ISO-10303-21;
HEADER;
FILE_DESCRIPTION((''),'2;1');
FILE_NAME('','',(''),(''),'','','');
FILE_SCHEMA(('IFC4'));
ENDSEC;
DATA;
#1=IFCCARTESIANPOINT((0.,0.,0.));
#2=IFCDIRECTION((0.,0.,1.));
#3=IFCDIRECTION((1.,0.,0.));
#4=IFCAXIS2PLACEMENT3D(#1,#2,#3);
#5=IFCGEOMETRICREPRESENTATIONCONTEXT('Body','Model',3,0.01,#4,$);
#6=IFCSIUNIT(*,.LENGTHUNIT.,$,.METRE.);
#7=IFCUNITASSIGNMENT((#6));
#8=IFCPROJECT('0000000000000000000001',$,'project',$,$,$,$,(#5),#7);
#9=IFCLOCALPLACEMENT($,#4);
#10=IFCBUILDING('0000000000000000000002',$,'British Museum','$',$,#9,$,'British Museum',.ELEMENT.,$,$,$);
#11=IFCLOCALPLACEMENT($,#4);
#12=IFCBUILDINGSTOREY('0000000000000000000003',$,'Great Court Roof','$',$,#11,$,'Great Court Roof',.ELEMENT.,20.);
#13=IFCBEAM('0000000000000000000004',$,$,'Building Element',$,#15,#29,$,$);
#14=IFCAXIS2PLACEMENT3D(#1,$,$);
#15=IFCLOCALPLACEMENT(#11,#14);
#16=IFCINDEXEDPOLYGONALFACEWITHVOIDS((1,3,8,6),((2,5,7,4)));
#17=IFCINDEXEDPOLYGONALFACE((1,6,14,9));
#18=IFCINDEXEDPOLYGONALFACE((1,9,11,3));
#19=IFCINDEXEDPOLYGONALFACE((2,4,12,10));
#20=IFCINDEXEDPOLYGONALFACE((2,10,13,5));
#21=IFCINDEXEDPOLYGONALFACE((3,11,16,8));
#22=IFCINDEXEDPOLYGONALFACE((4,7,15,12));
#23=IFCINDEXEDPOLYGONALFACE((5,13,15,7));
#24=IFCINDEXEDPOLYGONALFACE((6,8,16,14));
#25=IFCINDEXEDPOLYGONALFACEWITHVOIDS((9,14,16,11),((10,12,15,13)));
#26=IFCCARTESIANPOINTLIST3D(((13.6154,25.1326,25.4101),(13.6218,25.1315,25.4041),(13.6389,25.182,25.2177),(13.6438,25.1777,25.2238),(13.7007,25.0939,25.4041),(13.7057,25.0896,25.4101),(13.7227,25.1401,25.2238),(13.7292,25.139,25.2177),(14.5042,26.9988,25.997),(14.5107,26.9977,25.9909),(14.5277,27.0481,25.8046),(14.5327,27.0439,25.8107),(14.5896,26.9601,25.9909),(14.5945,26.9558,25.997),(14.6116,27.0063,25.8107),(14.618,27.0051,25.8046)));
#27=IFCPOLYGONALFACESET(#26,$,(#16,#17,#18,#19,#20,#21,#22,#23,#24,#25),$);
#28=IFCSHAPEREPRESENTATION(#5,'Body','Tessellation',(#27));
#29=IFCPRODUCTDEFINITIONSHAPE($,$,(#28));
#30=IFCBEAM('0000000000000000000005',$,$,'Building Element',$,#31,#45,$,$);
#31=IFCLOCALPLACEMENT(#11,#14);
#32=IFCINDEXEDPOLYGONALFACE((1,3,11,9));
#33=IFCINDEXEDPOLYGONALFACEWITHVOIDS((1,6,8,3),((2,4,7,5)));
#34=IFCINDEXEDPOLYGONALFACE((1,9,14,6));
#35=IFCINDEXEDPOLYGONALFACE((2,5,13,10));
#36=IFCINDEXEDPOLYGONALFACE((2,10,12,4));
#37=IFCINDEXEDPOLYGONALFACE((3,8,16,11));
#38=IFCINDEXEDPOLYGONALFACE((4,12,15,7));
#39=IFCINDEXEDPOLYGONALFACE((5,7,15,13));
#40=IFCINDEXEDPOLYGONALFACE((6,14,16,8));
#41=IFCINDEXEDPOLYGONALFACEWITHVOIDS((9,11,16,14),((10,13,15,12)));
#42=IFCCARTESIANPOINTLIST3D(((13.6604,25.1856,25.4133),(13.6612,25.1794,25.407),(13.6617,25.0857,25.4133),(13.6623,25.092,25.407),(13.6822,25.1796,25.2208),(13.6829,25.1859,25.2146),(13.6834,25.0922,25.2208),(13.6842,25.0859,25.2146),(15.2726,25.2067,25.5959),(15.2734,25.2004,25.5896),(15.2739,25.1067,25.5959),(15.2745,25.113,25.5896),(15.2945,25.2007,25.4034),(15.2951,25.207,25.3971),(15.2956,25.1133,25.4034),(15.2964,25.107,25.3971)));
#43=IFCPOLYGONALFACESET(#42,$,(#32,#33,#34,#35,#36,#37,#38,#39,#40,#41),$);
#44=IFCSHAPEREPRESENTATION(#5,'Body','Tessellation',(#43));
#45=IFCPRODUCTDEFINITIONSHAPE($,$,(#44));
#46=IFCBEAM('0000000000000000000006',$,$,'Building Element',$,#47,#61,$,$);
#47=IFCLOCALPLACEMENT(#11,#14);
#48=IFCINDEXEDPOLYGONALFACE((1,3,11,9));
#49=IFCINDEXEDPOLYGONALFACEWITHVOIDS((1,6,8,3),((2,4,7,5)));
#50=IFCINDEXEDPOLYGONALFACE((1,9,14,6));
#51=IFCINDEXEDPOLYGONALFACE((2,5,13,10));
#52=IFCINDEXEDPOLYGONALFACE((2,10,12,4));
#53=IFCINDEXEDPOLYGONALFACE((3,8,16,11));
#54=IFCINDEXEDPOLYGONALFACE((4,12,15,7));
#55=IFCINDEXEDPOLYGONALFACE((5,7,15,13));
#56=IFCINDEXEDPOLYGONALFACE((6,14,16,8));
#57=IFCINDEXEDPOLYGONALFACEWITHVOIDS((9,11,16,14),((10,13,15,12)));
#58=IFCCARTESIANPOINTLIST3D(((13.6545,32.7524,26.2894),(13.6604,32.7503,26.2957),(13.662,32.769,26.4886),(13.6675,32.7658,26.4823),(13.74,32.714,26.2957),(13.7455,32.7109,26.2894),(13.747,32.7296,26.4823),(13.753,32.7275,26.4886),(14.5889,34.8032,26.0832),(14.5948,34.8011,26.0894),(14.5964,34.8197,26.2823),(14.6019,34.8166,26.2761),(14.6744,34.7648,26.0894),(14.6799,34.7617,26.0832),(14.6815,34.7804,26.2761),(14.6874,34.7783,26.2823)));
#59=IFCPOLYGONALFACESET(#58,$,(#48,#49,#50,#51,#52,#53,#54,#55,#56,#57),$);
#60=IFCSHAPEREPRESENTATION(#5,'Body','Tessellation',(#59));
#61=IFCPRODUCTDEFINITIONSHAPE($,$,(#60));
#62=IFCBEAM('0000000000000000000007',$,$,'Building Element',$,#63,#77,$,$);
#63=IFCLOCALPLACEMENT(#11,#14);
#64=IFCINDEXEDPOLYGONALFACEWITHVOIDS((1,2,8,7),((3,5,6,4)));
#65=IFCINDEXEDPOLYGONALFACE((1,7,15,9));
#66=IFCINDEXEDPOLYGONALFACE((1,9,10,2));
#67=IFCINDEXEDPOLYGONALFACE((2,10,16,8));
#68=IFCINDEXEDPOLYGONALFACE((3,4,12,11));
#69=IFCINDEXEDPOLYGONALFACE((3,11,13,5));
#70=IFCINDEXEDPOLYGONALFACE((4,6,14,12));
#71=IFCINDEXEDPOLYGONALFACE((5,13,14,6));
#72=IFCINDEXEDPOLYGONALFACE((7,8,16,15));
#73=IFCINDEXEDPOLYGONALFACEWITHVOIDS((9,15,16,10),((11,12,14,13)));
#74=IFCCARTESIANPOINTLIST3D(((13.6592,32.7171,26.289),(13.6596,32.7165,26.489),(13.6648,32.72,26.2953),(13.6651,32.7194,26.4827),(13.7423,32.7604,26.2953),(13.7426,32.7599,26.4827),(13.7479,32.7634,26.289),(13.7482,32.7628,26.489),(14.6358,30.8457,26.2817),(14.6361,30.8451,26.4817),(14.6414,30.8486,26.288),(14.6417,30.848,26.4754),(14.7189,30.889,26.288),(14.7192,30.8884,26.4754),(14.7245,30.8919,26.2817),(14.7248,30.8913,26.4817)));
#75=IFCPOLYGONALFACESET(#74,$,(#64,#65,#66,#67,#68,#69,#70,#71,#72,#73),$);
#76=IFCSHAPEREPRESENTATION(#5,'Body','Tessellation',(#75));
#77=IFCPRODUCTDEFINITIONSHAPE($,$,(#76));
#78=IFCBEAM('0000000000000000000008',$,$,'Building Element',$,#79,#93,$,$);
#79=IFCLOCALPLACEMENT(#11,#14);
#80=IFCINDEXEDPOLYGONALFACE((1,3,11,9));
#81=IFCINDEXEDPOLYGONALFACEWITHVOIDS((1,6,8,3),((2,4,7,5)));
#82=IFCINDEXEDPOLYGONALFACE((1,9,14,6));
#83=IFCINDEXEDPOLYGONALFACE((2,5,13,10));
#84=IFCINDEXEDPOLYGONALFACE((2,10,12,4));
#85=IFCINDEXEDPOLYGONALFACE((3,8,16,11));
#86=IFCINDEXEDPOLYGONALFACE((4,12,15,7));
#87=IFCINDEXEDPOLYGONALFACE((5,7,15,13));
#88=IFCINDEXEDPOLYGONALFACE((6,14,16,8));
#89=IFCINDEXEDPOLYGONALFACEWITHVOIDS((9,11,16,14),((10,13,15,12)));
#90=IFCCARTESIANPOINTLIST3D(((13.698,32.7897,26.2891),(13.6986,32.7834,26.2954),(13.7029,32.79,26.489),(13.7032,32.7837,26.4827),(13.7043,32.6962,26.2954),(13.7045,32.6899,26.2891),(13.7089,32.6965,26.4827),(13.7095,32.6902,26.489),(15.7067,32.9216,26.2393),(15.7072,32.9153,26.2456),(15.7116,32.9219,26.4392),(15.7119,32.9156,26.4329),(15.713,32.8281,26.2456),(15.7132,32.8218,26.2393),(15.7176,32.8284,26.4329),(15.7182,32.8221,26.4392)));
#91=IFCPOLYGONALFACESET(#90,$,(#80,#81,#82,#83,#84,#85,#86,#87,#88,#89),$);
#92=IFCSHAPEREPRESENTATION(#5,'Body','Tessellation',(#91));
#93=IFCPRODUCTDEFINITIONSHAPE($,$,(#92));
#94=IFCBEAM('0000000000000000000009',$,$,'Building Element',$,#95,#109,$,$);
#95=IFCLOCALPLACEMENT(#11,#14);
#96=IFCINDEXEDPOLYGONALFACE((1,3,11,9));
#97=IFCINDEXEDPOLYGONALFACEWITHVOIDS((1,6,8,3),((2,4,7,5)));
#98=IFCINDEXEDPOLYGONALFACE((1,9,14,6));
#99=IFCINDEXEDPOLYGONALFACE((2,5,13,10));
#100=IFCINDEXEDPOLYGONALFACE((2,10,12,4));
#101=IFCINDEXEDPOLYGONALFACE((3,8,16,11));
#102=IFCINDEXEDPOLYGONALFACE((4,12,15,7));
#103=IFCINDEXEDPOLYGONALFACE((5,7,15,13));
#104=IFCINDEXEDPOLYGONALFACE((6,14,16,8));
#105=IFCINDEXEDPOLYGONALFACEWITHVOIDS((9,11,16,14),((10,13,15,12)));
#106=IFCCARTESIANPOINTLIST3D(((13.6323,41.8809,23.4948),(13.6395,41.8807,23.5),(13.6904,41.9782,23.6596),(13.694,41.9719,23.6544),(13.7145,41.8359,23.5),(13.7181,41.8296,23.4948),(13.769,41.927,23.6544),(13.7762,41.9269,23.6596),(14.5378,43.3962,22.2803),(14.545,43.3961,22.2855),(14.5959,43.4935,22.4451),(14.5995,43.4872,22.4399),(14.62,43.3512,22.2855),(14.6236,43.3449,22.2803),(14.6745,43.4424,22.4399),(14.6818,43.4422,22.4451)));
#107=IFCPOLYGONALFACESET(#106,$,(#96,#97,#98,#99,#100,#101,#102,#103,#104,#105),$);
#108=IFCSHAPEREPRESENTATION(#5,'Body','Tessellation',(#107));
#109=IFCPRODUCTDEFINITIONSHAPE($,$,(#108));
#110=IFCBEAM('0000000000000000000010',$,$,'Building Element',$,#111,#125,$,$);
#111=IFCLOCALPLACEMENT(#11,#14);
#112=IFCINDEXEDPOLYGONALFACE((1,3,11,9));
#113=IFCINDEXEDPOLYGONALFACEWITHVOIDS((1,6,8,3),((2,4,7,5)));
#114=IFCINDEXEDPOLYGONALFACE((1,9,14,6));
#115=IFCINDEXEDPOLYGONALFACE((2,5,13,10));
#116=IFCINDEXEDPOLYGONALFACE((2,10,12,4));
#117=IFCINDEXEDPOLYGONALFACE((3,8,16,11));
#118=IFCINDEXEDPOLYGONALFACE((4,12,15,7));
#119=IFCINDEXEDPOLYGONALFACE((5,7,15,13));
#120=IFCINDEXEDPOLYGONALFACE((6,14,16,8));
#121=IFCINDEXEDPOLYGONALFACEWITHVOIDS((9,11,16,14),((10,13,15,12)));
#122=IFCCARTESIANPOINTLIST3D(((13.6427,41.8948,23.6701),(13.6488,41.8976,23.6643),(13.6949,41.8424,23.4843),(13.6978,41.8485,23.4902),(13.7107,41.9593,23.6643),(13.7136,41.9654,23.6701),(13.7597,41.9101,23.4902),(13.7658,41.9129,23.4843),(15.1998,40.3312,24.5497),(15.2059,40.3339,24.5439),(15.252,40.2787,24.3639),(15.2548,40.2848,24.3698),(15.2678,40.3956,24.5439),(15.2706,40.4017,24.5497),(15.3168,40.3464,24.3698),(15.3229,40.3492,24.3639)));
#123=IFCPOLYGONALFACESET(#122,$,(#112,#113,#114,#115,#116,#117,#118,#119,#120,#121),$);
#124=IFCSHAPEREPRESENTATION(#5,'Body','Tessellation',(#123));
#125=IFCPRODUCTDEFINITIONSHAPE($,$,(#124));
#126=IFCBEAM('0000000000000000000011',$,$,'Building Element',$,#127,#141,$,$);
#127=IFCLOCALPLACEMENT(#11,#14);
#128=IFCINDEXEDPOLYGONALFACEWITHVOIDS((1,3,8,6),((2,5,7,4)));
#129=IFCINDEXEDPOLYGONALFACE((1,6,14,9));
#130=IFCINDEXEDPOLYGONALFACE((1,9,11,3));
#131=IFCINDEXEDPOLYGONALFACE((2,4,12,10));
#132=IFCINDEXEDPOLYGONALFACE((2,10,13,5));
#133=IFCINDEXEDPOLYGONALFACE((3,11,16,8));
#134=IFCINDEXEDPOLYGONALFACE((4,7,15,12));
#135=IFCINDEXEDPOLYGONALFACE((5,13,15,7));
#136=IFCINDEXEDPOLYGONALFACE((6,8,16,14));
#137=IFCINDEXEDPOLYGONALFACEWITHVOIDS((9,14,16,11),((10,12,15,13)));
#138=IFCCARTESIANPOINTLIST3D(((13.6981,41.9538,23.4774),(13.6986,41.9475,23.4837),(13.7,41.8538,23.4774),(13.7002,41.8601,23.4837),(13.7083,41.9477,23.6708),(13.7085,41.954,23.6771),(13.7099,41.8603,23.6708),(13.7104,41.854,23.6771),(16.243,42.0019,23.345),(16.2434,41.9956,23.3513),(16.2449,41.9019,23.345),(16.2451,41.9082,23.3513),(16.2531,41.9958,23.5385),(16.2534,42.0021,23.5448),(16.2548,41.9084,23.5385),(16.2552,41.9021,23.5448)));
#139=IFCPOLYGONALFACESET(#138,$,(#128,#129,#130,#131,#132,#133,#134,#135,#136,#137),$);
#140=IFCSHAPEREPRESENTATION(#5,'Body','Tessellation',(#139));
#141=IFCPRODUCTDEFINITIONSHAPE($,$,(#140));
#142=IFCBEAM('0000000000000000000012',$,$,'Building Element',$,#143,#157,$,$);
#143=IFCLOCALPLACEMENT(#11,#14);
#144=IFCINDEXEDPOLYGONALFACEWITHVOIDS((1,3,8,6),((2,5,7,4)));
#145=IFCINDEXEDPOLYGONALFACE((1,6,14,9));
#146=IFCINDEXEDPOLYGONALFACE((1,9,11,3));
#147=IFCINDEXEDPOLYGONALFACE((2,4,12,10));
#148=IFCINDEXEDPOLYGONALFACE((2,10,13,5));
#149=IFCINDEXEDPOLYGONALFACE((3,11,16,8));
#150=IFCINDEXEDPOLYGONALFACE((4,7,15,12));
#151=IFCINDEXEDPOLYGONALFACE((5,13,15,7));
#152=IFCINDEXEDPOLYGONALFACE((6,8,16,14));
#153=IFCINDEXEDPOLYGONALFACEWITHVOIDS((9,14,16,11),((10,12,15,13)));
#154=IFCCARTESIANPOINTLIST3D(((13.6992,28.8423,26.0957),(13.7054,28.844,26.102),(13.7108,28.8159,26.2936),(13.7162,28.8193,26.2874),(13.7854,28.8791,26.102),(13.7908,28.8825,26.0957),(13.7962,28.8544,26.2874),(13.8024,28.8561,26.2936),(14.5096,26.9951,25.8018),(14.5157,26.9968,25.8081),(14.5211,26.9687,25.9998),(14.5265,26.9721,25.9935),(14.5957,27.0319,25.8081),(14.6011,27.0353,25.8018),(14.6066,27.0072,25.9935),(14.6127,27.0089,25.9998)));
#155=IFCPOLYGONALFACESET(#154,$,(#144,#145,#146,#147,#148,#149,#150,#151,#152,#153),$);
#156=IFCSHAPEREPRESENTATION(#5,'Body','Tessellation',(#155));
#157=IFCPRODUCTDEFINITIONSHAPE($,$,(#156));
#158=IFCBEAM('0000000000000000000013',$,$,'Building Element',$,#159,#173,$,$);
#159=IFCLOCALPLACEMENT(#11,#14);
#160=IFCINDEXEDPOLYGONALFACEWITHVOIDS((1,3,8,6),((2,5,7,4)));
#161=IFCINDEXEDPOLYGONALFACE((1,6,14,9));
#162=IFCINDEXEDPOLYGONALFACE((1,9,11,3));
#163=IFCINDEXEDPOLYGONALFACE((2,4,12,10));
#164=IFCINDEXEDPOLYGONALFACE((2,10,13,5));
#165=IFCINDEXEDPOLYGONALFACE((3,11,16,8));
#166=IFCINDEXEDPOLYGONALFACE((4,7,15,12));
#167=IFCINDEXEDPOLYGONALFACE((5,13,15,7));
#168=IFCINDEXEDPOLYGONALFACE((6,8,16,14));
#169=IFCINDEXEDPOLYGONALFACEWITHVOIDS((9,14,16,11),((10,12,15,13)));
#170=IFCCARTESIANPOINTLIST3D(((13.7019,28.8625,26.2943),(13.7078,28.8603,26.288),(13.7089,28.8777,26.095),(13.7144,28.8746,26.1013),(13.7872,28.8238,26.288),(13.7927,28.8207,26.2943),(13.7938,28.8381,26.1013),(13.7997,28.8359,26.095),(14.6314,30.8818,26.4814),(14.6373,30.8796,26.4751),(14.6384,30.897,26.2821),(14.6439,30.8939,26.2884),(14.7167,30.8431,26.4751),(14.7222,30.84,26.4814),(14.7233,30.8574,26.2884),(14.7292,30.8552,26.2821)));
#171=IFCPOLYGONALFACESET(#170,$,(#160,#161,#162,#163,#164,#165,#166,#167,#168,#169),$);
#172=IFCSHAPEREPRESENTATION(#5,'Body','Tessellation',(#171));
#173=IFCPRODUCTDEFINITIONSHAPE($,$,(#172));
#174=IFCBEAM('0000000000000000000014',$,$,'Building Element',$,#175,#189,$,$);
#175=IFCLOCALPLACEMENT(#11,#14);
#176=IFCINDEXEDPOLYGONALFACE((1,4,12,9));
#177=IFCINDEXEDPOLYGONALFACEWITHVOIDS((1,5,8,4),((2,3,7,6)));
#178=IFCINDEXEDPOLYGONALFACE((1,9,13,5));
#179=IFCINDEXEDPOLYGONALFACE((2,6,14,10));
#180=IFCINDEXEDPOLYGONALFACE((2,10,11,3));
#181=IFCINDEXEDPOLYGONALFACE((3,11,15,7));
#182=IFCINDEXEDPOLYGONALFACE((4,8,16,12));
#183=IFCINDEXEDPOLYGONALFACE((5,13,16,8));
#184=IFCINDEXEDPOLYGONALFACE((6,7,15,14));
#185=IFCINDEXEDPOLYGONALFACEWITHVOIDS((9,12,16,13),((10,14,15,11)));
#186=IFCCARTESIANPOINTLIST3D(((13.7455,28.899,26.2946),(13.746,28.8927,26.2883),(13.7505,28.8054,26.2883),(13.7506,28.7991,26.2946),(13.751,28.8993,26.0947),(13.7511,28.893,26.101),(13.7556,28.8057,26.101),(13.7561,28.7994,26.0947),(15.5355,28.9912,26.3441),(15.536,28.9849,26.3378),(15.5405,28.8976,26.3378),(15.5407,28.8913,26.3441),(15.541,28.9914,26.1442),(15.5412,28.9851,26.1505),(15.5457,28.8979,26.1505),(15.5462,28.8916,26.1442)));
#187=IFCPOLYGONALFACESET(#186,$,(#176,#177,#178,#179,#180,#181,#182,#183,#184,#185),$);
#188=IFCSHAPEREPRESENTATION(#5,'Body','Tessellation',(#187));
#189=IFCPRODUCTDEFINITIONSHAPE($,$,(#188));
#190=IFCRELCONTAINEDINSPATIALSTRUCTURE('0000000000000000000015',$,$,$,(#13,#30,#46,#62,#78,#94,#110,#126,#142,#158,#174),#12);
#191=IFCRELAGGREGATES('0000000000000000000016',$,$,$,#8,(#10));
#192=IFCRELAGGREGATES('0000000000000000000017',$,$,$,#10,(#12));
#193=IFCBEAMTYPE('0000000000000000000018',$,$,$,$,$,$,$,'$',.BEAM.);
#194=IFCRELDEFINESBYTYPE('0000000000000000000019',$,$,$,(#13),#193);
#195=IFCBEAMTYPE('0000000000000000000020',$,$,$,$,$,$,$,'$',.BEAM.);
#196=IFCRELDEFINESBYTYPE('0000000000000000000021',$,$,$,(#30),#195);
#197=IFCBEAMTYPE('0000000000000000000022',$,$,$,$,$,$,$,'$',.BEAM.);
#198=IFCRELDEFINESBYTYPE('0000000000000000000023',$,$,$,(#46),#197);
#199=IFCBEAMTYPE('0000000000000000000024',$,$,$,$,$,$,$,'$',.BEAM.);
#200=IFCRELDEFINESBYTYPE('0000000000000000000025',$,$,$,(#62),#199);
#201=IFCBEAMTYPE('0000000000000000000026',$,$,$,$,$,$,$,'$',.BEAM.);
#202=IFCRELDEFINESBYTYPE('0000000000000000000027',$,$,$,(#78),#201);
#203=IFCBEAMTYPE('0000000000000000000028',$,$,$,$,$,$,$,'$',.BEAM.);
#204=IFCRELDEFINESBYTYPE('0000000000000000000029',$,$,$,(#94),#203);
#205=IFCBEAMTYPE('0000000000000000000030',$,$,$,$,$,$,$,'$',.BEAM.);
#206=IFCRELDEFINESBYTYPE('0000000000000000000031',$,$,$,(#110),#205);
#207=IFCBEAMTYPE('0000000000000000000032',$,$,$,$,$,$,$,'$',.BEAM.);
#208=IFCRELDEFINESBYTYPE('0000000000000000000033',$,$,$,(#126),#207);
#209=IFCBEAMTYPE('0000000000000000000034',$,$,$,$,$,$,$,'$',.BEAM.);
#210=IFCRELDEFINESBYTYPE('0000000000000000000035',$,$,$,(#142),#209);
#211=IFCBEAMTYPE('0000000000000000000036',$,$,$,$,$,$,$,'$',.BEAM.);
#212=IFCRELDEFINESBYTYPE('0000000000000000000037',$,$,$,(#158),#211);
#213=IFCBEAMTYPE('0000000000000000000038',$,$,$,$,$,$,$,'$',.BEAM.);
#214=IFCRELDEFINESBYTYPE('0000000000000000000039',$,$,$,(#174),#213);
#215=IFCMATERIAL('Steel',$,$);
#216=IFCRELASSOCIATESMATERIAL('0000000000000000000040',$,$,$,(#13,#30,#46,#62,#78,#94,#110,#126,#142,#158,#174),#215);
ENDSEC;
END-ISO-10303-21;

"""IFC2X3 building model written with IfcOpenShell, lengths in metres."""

from ifc_helpers import new_model, si_unit, frame, origin_with_axes, origin_2d, place, context, project, spatial, hollow_rectangle, extrude, material, type_object, element, save


model = new_model("IFC2X3")

# Units and contexts
model_context = context("Model", 3, precision=0.01, world=origin_with_axes(), identifier="Body")
ifc_project = project(units=[si_unit("LENGTHUNIT", "METRE")], contexts=[model_context])

# Building, storey
building_placement = place(None, origin_with_axes())
building = spatial("IfcBuilding", under=ifc_project, at=building_placement, Name="British Museum", Description="$", LongName="British Museum", CompositionType="ELEMENT")
storey_placement = place(None, origin_with_axes())
storey = spatial("IfcBuildingStorey", under=building, at=storey_placement, Name="Great Court Roof", Description="$", LongName="Great Court Roof", CompositionType="ELEMENT", Elevation=20.0)

# Beams
ifc_material = material(Name="Steel")
beam_type_1 = type_object("IfcBeamType", ElementType="$", PredefinedType="BEAM")
beam_1_placement = place(None, origin_with_axes())
element("IfcBeam", 1, at=beam_1_placement, inside=storey, type_object=beam_type_1, material=ifc_material, Description="Building Element", context=model_context, shape_type="SweptSolid", body=[
    extrude(hollow_rectangle(XDim=0.1, YDim=0.2, WallThickness=0.0063, InnerFilletRadius=-0.0063, OuterFilletRadius=0.0, at=origin_2d()), frame((13.6723, 25.1358, 25.3139), z_axis=(0.413662, 0.868498, 0.273121), x_axis=(-0.902823, 0.430012, 0.0)), (0.0, 0.0, 1.0), 2.1487),
])
beam_type_2 = type_object("IfcBeamType", ElementType="$", PredefinedType="BEAM")
beam_2_placement = place(None, origin_with_axes())
element("IfcBeam", 2, at=beam_2_placement, inside=storey, type_object=beam_type_2, material=ifc_material, Description="Building Element", context=model_context, shape_type="SweptSolid", body=[
    extrude(hollow_rectangle(XDim=0.1, YDim=0.2, WallThickness=0.0063, InnerFilletRadius=-0.0063, OuterFilletRadius=0.0, at=origin_2d()), frame((13.6723, 25.1358, 25.3139), z_axis=(0.993567, 0.012965, 0.112502), x_axis=(-0.013048, 0.999915, 0.0)), (0.0, 0.0, 1.0), 1.6227),
])
beam_type_3 = type_object("IfcBeamType", ElementType="$", PredefinedType="BEAM")
beam_3_placement = place(None, origin_with_axes())
element("IfcBeam", 3, at=beam_3_placement, inside=storey, type_object=beam_type_3, material=ifc_material, Description="Building Element", context=model_context, shape_type="SweptSolid", body=[
    extrude(hollow_rectangle(XDim=0.1, YDim=0.2, WallThickness=0.0063, InnerFilletRadius=-0.0063, OuterFilletRadius=0.0, at=origin_2d()), frame((13.7037, 32.7399, 26.389), z_axis=(0.412902, 0.906203, -0.091149), x_axis=(-0.909991, 0.414628, 0.0)), (0.0, 0.0, 1.0), 2.263),
])
beam_type_4 = type_object("IfcBeamType", ElementType="$", PredefinedType="BEAM")
beam_4_placement = place(None, origin_with_axes())
element("IfcBeam", 4, at=beam_4_placement, inside=storey, type_object=beam_type_4, material=ifc_material, Description="Building Element", context=model_context, shape_type="SweptSolid", body=[
    extrude(hollow_rectangle(XDim=0.1, YDim=0.2, WallThickness=0.0063, InnerFilletRadius=-0.0063, OuterFilletRadius=0.0, at=origin_2d()), frame((13.7037, 32.7399, 26.389), z_axis=(0.46262, -0.88655, -0.003454), x_axis=(0.886555, 0.462623, 0.0)), (0.0, 0.0, 1.0), 2.1109),
])
beam_type_5 = type_object("IfcBeamType", ElementType="$", PredefinedType="BEAM")
beam_5_placement = place(None, origin_with_axes())
element("IfcBeam", 5, at=beam_5_placement, inside=storey, type_object=beam_type_5, material=ifc_material, Description="Building Element", context=model_context, shape_type="SweptSolid", body=[
    extrude(hollow_rectangle(XDim=0.1, YDim=0.2, WallThickness=0.0063, InnerFilletRadius=-0.0063, OuterFilletRadius=0.0, at=origin_2d()), frame((13.7037, 32.7399, 26.389), z_axis=(0.997546, 0.065496, -0.024723), x_axis=(-0.065516, 0.997852, 0.0)), (0.0, 0.0, 1.0), 2.0136),
])
beam_type_6 = type_object("IfcBeamType", ElementType="$", PredefinedType="BEAM")
beam_6_placement = place(None, origin_with_axes())
element("IfcBeam", 6, at=beam_6_placement, inside=storey, type_object=beam_type_6, material=ifc_material, Description="Building Element", context=model_context, shape_type="SweptSolid", body=[
    extrude(hollow_rectangle(XDim=0.1, YDim=0.2, WallThickness=0.0063, InnerFilletRadius=-0.0063, OuterFilletRadius=0.0, at=origin_2d()), frame((13.7043, 41.9039, 23.5772), z_axis=(0.422597, 0.707203, -0.566812), x_axis=(-0.858415, 0.512956, 0.0)), (0.0, 0.0, 1.0), 2.1427),
])
beam_type_7 = type_object("IfcBeamType", ElementType="$", PredefinedType="BEAM")
beam_7_placement = place(None, origin_with_axes())
element("IfcBeam", 7, at=beam_7_placement, inside=storey, type_object=beam_type_7, material=ifc_material, Description="Building Element", context=model_context, shape_type="SweptSolid", body=[
    extrude(hollow_rectangle(XDim=0.1, YDim=0.2, WallThickness=0.0063, InnerFilletRadius=-0.0063, OuterFilletRadius=0.0, at=origin_2d()), frame((13.7043, 41.9039, 23.5772), z_axis=(0.655456, -0.658235, 0.370275), x_axis=(0.708601, 0.70561, 0.0)), (0.0, 0.0, 1.0), 2.3756),
])
beam_type_8 = type_object("IfcBeamType", ElementType="$", PredefinedType="BEAM")
beam_8_placement = place(None, origin_with_axes())
element("IfcBeam", 8, at=beam_8_placement, inside=storey, type_object=beam_type_8, material=ifc_material, Description="Building Element", context=model_context, shape_type="SweptSolid", body=[
    extrude(hollow_rectangle(XDim=0.1, YDim=0.2, WallThickness=0.0063, InnerFilletRadius=-0.0063, OuterFilletRadius=0.0, at=origin_2d()), frame((13.7043, 41.9039, 23.5772), z_axis=(0.998473, 0.01887, -0.051922), x_axis=(-0.018896, 0.999821, 0.0)), (0.0, 0.0, 1.0), 2.5488),
])
beam_type_9 = type_object("IfcBeamType", ElementType="$", PredefinedType="BEAM")
beam_9_placement = place(None, origin_with_axes())
element("IfcBeam", 9, at=beam_9_placement, inside=storey, type_object=beam_type_9, material=ifc_material, Description="Building Element", context=model_context, shape_type="SweptSolid", body=[
    extrude(hollow_rectangle(XDim=0.1, YDim=0.2, WallThickness=0.0063, InnerFilletRadius=-0.0063, OuterFilletRadius=0.0, at=origin_2d()), frame((13.7508, 28.8492, 26.1947), z_axis=(0.397528, -0.906194, -0.144164), x_axis=(0.915761, 0.401724, 0.0)), (0.0, 0.0, 1.0), 2.0384),
])
beam_type_10 = type_object("IfcBeamType", ElementType="$", PredefinedType="BEAM")
beam_10_placement = place(None, origin_with_axes())
element("IfcBeam", 10, at=beam_10_placement, inside=storey, type_object=beam_type_10, material=ifc_material, Description="Building Element", context=model_context, shape_type="SweptSolid", body=[
    extrude(hollow_rectangle(XDim=0.1, YDim=0.2, WallThickness=0.0063, InnerFilletRadius=-0.0063, OuterFilletRadius=0.0, at=origin_2d()), frame((13.7508, 28.8492, 26.1947), z_axis=(0.416659, 0.905187, 0.083856), x_axis=(-0.908387, 0.418131, 0.0)), (0.0, 0.0, 1.0), 2.2308),
])
beam_type_11 = type_object("IfcBeamType", ElementType="$", PredefinedType="BEAM")
beam_11_placement = place(None, origin_with_axes())
element("IfcBeam", 11, at=beam_11_placement, inside=storey, type_object=beam_type_11, material=ifc_material, Description="Building Element", context=model_context, shape_type="SweptSolid", body=[
    extrude(hollow_rectangle(XDim=0.1, YDim=0.2, WallThickness=0.0063, InnerFilletRadius=-0.0063, OuterFilletRadius=0.0, at=origin_2d()), frame((13.7508, 28.8492, 26.1947), z_axis=(0.998296, 0.05141, 0.027601), x_axis=(-0.05143, 0.998677, 0.0)), (0.0, 0.0, 1.0), 1.7931),
])

save(model, "model.ifc")
